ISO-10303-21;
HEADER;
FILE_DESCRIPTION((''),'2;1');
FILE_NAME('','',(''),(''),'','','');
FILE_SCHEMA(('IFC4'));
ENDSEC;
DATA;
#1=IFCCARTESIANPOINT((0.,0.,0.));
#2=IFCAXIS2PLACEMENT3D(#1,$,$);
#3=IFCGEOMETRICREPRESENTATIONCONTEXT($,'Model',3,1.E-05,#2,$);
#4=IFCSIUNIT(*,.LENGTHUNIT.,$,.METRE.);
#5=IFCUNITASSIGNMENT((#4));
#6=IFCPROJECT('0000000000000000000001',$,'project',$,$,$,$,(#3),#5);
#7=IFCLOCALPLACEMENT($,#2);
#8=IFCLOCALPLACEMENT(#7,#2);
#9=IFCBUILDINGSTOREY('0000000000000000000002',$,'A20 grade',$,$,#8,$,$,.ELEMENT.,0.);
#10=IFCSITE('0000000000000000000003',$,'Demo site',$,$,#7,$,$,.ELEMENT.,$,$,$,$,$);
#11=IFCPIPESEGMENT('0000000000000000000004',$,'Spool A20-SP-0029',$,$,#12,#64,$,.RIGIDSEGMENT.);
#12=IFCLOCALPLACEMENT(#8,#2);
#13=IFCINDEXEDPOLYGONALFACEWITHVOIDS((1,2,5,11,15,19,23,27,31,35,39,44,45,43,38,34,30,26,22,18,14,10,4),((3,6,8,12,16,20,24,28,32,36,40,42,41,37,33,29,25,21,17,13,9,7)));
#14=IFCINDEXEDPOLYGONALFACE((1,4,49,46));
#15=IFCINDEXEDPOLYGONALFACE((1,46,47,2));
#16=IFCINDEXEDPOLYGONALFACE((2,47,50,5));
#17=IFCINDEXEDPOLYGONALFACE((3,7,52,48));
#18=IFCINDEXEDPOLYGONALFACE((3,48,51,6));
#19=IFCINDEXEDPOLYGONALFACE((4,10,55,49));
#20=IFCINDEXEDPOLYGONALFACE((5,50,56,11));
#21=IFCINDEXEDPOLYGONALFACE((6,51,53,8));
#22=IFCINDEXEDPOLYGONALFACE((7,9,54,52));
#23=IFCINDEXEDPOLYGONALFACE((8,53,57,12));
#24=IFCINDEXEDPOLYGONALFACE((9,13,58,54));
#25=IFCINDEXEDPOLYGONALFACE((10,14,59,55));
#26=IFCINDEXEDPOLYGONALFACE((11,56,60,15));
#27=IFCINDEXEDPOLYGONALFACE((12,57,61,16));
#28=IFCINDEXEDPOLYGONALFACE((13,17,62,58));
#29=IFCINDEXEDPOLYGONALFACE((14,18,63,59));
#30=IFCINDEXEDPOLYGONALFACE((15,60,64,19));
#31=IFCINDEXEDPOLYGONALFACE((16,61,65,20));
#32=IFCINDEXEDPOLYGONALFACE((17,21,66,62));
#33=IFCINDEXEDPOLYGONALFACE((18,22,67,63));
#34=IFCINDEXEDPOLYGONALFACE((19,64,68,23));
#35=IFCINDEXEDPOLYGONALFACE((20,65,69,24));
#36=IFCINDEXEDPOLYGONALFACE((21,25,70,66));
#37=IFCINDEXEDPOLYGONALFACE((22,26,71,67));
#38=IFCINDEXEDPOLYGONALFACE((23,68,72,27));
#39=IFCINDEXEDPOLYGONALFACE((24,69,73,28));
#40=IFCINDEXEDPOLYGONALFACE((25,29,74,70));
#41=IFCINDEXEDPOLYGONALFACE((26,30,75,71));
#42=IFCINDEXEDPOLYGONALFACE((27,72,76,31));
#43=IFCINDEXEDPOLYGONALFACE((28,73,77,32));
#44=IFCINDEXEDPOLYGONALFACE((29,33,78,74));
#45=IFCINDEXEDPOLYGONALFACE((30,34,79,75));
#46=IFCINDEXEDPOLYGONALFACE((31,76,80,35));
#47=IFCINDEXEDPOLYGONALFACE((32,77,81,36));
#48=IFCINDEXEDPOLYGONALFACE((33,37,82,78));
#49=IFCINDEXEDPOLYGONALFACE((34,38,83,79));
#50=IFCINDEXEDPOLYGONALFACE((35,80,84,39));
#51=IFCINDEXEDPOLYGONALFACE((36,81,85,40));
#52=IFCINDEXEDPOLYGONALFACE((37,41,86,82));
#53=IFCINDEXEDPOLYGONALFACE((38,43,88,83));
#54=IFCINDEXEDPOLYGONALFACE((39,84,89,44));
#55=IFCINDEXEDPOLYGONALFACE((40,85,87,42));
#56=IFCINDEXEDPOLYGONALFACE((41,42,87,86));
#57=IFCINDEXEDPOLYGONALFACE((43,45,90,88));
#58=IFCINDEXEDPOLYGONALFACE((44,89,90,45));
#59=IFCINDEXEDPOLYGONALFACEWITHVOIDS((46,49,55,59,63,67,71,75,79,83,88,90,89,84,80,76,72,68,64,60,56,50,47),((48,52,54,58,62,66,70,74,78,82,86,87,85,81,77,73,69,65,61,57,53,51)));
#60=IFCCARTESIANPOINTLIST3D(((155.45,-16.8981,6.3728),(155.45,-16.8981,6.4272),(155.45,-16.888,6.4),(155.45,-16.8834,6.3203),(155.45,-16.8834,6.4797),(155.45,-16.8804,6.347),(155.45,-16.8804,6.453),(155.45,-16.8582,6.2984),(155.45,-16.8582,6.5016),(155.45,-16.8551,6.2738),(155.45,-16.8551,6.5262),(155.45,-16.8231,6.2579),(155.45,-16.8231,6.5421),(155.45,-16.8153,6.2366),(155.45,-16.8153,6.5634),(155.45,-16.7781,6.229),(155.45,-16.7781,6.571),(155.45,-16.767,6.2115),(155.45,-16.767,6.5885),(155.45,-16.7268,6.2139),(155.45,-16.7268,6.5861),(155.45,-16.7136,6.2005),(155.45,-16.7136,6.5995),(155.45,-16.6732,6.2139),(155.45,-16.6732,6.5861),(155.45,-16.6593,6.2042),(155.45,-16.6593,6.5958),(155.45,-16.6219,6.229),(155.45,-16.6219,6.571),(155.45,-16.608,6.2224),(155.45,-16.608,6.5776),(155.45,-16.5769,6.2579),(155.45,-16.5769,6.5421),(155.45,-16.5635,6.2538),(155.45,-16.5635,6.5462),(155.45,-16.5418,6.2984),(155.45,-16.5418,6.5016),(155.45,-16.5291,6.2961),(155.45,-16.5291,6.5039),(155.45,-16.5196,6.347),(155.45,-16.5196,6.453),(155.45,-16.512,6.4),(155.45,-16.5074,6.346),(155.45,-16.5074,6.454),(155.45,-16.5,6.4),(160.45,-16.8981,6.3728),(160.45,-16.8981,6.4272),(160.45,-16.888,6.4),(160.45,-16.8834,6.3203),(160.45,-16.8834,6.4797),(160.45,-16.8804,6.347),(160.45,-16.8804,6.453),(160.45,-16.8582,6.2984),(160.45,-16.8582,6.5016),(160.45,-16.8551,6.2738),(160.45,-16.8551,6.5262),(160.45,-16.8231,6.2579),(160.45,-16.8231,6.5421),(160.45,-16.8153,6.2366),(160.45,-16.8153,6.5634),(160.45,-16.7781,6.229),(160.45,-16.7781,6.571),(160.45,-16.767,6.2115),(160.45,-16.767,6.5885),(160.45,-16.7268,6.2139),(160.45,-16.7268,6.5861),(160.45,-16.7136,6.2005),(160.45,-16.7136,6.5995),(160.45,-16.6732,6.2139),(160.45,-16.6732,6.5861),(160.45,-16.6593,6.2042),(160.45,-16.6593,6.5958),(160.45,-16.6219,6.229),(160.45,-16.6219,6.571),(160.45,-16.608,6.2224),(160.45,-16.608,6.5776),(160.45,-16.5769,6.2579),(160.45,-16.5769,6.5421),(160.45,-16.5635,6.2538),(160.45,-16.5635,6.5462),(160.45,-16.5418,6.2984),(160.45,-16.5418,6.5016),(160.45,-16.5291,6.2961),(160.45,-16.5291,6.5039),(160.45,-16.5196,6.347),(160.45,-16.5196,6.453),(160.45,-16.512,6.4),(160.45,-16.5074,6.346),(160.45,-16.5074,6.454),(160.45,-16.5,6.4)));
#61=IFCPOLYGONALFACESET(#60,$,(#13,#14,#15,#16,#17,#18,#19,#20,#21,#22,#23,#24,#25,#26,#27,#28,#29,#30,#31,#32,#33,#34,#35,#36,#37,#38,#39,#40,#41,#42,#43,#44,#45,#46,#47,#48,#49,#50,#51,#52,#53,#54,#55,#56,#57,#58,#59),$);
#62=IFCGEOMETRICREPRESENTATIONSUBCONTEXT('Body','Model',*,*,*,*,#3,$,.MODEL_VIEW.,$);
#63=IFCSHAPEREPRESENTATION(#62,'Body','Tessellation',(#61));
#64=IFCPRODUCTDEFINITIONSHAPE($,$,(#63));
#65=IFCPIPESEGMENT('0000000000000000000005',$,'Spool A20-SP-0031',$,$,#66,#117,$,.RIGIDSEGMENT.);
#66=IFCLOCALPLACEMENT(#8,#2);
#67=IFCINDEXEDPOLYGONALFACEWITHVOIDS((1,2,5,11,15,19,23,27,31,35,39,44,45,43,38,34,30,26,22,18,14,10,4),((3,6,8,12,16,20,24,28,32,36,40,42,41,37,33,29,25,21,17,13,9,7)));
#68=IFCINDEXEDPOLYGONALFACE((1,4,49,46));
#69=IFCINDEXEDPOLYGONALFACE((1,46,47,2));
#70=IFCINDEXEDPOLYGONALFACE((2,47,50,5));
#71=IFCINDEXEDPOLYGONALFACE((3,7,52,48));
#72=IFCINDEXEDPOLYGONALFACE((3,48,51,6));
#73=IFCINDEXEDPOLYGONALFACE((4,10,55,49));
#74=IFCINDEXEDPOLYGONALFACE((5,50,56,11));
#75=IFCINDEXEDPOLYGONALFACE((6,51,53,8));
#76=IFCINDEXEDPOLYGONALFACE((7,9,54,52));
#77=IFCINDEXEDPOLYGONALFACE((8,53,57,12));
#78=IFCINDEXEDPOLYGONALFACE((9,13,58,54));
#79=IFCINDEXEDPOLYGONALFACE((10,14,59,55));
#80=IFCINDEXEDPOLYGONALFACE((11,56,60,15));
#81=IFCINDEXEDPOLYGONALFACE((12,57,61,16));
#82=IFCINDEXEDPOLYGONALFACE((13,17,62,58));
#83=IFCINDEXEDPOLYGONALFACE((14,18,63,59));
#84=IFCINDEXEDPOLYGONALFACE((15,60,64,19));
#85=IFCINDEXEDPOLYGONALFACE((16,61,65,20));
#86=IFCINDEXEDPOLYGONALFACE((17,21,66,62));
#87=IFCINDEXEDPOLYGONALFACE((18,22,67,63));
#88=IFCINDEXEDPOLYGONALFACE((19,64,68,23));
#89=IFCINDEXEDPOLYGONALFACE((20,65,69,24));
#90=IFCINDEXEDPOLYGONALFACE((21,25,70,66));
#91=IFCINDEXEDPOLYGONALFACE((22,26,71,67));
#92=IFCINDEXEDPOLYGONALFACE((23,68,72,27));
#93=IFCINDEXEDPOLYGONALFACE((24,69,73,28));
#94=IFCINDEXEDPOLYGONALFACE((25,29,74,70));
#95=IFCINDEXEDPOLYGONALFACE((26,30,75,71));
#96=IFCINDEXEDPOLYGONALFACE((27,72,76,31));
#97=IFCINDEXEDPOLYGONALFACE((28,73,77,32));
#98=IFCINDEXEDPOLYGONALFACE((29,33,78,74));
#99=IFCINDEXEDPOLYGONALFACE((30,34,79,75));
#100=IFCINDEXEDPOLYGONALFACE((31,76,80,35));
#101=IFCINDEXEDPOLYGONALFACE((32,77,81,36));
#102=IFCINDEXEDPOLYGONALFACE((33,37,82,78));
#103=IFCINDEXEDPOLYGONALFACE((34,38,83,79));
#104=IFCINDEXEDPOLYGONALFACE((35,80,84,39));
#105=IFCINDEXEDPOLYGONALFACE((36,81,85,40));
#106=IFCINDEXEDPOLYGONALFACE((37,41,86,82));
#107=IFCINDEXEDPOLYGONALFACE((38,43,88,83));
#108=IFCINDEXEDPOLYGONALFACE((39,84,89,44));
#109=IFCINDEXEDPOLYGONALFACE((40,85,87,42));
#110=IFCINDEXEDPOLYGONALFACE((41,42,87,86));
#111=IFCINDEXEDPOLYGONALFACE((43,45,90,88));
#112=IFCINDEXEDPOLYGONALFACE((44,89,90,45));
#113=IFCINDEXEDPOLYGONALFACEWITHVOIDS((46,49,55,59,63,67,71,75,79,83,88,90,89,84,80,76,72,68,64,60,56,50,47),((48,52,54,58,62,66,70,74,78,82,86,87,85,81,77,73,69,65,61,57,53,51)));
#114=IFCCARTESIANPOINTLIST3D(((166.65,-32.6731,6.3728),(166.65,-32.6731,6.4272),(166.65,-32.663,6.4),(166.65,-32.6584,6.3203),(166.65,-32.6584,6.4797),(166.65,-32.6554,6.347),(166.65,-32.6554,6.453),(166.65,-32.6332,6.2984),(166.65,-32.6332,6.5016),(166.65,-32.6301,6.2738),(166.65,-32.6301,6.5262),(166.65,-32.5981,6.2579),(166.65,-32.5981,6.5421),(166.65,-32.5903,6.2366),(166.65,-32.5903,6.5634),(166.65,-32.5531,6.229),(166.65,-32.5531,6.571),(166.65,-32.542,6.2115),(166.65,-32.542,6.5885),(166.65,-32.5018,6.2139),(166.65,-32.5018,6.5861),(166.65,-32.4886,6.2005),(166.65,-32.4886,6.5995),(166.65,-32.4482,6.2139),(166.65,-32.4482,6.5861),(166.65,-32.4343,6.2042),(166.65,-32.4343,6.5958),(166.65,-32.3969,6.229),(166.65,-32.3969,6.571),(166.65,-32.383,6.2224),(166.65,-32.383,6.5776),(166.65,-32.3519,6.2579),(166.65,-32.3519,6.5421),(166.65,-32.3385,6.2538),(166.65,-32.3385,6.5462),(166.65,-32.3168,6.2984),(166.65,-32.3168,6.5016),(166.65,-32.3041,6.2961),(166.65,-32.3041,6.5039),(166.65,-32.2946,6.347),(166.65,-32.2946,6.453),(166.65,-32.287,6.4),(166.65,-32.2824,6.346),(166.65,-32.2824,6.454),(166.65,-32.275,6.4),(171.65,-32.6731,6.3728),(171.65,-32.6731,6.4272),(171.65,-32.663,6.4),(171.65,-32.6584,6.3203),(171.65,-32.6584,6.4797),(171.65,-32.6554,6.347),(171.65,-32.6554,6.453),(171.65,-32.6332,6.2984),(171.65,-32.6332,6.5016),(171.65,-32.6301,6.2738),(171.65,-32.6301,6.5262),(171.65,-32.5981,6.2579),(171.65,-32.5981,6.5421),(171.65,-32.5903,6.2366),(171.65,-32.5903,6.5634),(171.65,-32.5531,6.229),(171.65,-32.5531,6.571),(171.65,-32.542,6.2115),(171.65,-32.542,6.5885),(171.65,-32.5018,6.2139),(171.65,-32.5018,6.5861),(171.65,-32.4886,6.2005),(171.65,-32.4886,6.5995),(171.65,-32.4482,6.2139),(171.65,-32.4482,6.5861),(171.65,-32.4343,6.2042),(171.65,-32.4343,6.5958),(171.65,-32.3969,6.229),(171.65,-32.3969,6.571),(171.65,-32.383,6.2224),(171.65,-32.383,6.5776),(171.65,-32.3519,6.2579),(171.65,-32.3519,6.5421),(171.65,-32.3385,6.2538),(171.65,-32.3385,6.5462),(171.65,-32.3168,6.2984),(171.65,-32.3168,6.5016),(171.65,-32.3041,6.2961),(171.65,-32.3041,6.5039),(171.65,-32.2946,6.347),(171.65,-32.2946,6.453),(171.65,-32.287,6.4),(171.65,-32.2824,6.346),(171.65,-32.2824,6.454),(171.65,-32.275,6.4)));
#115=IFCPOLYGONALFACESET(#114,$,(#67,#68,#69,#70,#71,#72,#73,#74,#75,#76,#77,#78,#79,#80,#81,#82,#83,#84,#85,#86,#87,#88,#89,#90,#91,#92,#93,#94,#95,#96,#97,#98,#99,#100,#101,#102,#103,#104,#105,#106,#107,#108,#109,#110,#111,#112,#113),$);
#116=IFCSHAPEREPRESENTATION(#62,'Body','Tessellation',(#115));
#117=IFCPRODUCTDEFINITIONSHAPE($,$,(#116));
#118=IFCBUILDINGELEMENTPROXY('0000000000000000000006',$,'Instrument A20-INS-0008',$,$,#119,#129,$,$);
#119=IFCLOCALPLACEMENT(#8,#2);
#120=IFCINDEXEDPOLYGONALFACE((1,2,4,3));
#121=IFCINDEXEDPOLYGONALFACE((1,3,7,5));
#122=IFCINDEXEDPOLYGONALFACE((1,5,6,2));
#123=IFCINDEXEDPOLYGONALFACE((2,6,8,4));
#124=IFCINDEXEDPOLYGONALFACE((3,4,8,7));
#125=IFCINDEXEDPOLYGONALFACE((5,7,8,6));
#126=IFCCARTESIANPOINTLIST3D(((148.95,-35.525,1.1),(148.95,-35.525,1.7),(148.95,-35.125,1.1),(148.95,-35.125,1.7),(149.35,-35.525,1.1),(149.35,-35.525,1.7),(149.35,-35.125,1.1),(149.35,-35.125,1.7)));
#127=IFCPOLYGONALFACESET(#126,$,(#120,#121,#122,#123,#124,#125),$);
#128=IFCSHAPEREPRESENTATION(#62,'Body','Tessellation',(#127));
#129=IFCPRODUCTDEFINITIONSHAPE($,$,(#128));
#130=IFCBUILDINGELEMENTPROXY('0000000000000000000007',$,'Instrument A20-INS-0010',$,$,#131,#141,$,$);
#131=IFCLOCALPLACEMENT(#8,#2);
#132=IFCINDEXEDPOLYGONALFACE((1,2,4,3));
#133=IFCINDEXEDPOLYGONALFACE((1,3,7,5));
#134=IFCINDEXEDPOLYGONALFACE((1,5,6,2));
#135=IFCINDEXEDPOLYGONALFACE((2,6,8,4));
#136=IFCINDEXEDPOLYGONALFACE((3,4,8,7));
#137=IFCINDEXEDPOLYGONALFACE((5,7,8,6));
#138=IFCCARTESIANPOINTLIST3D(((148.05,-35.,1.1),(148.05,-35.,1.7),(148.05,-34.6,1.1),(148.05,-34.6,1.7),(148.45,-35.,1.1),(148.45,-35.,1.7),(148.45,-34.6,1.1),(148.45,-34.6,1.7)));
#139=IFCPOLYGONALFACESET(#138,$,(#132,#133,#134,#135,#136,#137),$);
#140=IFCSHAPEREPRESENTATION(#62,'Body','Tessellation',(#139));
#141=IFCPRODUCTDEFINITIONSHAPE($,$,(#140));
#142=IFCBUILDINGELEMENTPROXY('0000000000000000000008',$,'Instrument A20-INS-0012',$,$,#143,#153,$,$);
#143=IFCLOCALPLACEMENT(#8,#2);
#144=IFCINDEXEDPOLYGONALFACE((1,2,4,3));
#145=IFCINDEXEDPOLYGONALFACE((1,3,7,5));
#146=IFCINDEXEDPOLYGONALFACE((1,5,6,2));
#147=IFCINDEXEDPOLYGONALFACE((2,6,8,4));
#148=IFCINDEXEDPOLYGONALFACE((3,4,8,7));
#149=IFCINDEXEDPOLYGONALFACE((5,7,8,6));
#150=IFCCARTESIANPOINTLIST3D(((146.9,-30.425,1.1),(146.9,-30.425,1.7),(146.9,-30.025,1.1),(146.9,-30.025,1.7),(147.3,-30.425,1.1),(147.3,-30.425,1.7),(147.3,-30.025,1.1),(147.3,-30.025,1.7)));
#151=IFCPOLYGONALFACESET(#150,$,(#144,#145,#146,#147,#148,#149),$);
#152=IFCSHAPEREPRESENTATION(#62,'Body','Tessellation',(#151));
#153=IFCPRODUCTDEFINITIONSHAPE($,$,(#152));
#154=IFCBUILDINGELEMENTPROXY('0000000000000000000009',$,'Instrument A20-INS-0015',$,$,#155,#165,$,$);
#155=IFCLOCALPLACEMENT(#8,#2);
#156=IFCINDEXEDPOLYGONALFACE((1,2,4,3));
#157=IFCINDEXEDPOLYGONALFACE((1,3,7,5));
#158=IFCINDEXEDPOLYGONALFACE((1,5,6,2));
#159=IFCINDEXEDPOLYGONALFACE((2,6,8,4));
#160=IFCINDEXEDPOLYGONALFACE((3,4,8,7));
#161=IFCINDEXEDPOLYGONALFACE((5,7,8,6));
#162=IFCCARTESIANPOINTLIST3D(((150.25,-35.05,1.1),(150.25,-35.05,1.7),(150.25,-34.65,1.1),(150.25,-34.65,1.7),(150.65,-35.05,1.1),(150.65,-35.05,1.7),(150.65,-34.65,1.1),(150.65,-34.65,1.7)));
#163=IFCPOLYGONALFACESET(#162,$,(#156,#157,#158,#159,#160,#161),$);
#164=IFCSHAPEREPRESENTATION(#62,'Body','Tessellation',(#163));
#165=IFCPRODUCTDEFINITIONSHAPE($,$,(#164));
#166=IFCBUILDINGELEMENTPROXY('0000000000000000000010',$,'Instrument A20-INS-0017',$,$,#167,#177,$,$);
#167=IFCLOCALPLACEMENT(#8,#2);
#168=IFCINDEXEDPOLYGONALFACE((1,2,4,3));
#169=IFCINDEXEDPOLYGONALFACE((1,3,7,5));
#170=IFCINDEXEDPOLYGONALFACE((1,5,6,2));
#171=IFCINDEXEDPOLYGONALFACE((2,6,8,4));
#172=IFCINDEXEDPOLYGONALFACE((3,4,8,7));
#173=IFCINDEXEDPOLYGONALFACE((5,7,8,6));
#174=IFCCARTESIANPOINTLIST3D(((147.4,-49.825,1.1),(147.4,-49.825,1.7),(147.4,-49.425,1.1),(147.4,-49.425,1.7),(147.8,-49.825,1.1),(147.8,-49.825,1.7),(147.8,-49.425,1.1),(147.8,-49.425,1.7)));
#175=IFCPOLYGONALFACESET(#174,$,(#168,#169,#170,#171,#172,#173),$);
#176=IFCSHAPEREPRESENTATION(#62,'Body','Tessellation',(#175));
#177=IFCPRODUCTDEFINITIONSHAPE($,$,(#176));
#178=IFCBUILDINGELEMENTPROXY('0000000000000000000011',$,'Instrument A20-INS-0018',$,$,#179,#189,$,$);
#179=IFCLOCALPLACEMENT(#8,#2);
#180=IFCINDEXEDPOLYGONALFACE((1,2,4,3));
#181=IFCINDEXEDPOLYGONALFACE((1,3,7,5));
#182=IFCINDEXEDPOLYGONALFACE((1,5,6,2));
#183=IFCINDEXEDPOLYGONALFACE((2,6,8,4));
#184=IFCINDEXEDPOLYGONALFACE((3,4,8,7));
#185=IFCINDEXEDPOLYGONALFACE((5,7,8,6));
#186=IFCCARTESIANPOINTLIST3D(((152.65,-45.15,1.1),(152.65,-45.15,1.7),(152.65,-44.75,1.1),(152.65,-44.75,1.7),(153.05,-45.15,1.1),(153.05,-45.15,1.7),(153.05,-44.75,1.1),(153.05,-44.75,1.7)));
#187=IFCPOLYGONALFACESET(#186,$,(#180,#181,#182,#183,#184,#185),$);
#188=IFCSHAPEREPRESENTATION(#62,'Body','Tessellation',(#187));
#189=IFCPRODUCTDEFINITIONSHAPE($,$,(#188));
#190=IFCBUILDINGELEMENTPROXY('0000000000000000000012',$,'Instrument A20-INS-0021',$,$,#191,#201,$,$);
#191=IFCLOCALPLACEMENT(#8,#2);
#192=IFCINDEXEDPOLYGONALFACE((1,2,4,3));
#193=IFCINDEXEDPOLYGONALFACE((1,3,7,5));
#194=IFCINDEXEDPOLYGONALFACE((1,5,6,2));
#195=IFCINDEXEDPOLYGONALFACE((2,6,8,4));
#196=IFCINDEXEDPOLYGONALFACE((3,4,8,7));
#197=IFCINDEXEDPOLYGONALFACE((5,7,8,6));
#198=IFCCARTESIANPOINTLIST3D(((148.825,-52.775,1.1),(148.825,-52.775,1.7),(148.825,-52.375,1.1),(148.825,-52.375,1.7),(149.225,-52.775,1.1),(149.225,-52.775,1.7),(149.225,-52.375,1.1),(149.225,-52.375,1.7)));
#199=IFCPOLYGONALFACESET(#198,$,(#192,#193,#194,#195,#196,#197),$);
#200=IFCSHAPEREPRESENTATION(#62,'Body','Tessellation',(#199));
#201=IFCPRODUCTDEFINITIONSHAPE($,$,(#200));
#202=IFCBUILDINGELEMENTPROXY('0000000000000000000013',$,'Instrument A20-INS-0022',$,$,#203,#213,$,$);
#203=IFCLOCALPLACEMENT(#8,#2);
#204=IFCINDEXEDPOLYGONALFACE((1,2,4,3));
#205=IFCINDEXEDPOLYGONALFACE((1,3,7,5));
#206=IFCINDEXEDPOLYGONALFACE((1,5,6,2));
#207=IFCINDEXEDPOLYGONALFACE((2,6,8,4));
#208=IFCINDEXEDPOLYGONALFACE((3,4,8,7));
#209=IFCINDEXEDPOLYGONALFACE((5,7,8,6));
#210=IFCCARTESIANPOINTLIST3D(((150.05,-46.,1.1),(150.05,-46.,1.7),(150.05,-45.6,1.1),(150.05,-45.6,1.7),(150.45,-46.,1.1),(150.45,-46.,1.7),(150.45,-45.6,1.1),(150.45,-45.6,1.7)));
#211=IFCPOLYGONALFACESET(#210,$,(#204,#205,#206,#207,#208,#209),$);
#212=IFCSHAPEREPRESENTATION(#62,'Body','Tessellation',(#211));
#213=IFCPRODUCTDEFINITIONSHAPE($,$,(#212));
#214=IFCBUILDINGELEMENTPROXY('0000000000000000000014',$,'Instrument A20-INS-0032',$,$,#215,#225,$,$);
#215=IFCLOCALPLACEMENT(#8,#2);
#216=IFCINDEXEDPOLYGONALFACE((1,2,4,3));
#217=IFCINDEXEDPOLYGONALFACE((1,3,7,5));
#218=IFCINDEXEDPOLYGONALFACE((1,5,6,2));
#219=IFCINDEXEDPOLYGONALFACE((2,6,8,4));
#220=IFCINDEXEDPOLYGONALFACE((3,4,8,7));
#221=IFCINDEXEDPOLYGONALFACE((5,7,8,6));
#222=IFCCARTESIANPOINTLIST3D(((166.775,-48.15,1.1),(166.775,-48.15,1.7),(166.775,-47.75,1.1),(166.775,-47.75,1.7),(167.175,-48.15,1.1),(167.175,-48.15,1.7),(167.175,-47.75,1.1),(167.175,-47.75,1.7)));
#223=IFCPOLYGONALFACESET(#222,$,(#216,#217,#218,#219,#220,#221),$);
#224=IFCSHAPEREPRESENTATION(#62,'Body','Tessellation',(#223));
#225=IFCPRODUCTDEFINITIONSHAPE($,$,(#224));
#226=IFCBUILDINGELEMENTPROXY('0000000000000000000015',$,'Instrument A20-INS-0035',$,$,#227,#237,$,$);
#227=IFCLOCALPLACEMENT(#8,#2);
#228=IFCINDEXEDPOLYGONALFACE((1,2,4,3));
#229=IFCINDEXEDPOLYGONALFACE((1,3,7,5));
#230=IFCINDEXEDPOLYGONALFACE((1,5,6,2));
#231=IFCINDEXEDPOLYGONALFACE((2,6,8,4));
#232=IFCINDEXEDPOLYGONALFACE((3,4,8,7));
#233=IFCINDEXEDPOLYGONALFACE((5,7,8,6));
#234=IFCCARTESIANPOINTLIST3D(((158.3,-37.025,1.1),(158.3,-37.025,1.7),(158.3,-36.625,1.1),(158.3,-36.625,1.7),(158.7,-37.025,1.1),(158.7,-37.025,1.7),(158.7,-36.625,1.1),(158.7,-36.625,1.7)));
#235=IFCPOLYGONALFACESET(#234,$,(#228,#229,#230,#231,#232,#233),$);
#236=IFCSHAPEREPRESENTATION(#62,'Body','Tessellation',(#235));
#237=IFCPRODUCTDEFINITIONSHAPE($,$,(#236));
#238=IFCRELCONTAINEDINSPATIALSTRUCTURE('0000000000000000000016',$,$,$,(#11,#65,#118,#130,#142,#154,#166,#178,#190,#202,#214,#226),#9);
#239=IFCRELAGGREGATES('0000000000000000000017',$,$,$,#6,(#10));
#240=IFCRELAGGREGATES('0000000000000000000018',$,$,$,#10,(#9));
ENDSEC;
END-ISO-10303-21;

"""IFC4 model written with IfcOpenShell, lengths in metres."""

from ifc_helpers import new_model, si_unit, frame, origin, place, context, subcontext, project, spatial, rectangle, hollow_circle, extrude, element, save


model = new_model("IFC4")

# Units and contexts
model_context = context("Model", 3, precision=1e-05, world=origin())
body_context = subcontext(model_context, "Body", "Model", "MODEL_VIEW")
ifc_project = project(units=[si_unit("LENGTHUNIT", "METRE")], contexts=[model_context])

# Site, storey
site_placement = place(None, origin())
site = spatial("IfcSite", under=ifc_project, at=site_placement, Name="Demo site", CompositionType="ELEMENT")
storey_placement = place(site_placement, origin())
storey = spatial("IfcBuildingStorey", under=site, at=storey_placement, Name="A20 grade", CompositionType="ELEMENT", Elevation=0.0)

# Pipe segments
for number, where, name in (
    (1, (155.45, -16.7, 6.4), "Spool A20-SP-0029"),
    (2, (166.65, -32.475, 6.4), "Spool A20-SP-0031"),
):
    element("IfcPipeSegment", number, at=place(storey_placement, frame(where)), inside=storey, Name=name, PredefinedType="RIGIDSEGMENT", context=body_context, shape_type="SweptSolid", body=[
        extrude(hollow_circle(Radius=0.2, WallThickness=0.012), frame((0.0, 0.0, 0.0), z_axis=(1.0, 0.0, 0.0), x_axis=(0.0, 1.0, 0.0)), (0.0, 0.0, 1.0), 5.0),
    ])

# Building element proxies
for number, where, name in (
    (3, (149.15, -35.325, 1.1), "Instrument A20-INS-0008"),
    (4, (148.25, -34.8, 1.1), "Instrument A20-INS-0010"),
    (5, (147.1, -30.225, 1.1), "Instrument A20-INS-0012"),
    (6, (150.45, -34.85, 1.1), "Instrument A20-INS-0015"),
    (7, (147.6, -49.625, 1.1), "Instrument A20-INS-0017"),
    (8, (152.85, -44.95, 1.1), "Instrument A20-INS-0018"),
    (9, (149.025, -52.575, 1.1), "Instrument A20-INS-0021"),
    (10, (150.25, -45.8, 1.1), "Instrument A20-INS-0022"),
    (11, (166.975, -47.95, 1.1), "Instrument A20-INS-0032"),
    (12, (158.5, -36.825, 1.1), "Instrument A20-INS-0035"),
):
    element("IfcBuildingElementProxy", number, at=place(storey_placement, frame(where)), inside=storey, Name=name, context=body_context, shape_type="SweptSolid", body=[
        extrude(rectangle(XDim=0.4, YDim=0.4), origin(), (0.0, 0.0, 1.0), 0.6),
    ])

save(model, "model.ifc")
